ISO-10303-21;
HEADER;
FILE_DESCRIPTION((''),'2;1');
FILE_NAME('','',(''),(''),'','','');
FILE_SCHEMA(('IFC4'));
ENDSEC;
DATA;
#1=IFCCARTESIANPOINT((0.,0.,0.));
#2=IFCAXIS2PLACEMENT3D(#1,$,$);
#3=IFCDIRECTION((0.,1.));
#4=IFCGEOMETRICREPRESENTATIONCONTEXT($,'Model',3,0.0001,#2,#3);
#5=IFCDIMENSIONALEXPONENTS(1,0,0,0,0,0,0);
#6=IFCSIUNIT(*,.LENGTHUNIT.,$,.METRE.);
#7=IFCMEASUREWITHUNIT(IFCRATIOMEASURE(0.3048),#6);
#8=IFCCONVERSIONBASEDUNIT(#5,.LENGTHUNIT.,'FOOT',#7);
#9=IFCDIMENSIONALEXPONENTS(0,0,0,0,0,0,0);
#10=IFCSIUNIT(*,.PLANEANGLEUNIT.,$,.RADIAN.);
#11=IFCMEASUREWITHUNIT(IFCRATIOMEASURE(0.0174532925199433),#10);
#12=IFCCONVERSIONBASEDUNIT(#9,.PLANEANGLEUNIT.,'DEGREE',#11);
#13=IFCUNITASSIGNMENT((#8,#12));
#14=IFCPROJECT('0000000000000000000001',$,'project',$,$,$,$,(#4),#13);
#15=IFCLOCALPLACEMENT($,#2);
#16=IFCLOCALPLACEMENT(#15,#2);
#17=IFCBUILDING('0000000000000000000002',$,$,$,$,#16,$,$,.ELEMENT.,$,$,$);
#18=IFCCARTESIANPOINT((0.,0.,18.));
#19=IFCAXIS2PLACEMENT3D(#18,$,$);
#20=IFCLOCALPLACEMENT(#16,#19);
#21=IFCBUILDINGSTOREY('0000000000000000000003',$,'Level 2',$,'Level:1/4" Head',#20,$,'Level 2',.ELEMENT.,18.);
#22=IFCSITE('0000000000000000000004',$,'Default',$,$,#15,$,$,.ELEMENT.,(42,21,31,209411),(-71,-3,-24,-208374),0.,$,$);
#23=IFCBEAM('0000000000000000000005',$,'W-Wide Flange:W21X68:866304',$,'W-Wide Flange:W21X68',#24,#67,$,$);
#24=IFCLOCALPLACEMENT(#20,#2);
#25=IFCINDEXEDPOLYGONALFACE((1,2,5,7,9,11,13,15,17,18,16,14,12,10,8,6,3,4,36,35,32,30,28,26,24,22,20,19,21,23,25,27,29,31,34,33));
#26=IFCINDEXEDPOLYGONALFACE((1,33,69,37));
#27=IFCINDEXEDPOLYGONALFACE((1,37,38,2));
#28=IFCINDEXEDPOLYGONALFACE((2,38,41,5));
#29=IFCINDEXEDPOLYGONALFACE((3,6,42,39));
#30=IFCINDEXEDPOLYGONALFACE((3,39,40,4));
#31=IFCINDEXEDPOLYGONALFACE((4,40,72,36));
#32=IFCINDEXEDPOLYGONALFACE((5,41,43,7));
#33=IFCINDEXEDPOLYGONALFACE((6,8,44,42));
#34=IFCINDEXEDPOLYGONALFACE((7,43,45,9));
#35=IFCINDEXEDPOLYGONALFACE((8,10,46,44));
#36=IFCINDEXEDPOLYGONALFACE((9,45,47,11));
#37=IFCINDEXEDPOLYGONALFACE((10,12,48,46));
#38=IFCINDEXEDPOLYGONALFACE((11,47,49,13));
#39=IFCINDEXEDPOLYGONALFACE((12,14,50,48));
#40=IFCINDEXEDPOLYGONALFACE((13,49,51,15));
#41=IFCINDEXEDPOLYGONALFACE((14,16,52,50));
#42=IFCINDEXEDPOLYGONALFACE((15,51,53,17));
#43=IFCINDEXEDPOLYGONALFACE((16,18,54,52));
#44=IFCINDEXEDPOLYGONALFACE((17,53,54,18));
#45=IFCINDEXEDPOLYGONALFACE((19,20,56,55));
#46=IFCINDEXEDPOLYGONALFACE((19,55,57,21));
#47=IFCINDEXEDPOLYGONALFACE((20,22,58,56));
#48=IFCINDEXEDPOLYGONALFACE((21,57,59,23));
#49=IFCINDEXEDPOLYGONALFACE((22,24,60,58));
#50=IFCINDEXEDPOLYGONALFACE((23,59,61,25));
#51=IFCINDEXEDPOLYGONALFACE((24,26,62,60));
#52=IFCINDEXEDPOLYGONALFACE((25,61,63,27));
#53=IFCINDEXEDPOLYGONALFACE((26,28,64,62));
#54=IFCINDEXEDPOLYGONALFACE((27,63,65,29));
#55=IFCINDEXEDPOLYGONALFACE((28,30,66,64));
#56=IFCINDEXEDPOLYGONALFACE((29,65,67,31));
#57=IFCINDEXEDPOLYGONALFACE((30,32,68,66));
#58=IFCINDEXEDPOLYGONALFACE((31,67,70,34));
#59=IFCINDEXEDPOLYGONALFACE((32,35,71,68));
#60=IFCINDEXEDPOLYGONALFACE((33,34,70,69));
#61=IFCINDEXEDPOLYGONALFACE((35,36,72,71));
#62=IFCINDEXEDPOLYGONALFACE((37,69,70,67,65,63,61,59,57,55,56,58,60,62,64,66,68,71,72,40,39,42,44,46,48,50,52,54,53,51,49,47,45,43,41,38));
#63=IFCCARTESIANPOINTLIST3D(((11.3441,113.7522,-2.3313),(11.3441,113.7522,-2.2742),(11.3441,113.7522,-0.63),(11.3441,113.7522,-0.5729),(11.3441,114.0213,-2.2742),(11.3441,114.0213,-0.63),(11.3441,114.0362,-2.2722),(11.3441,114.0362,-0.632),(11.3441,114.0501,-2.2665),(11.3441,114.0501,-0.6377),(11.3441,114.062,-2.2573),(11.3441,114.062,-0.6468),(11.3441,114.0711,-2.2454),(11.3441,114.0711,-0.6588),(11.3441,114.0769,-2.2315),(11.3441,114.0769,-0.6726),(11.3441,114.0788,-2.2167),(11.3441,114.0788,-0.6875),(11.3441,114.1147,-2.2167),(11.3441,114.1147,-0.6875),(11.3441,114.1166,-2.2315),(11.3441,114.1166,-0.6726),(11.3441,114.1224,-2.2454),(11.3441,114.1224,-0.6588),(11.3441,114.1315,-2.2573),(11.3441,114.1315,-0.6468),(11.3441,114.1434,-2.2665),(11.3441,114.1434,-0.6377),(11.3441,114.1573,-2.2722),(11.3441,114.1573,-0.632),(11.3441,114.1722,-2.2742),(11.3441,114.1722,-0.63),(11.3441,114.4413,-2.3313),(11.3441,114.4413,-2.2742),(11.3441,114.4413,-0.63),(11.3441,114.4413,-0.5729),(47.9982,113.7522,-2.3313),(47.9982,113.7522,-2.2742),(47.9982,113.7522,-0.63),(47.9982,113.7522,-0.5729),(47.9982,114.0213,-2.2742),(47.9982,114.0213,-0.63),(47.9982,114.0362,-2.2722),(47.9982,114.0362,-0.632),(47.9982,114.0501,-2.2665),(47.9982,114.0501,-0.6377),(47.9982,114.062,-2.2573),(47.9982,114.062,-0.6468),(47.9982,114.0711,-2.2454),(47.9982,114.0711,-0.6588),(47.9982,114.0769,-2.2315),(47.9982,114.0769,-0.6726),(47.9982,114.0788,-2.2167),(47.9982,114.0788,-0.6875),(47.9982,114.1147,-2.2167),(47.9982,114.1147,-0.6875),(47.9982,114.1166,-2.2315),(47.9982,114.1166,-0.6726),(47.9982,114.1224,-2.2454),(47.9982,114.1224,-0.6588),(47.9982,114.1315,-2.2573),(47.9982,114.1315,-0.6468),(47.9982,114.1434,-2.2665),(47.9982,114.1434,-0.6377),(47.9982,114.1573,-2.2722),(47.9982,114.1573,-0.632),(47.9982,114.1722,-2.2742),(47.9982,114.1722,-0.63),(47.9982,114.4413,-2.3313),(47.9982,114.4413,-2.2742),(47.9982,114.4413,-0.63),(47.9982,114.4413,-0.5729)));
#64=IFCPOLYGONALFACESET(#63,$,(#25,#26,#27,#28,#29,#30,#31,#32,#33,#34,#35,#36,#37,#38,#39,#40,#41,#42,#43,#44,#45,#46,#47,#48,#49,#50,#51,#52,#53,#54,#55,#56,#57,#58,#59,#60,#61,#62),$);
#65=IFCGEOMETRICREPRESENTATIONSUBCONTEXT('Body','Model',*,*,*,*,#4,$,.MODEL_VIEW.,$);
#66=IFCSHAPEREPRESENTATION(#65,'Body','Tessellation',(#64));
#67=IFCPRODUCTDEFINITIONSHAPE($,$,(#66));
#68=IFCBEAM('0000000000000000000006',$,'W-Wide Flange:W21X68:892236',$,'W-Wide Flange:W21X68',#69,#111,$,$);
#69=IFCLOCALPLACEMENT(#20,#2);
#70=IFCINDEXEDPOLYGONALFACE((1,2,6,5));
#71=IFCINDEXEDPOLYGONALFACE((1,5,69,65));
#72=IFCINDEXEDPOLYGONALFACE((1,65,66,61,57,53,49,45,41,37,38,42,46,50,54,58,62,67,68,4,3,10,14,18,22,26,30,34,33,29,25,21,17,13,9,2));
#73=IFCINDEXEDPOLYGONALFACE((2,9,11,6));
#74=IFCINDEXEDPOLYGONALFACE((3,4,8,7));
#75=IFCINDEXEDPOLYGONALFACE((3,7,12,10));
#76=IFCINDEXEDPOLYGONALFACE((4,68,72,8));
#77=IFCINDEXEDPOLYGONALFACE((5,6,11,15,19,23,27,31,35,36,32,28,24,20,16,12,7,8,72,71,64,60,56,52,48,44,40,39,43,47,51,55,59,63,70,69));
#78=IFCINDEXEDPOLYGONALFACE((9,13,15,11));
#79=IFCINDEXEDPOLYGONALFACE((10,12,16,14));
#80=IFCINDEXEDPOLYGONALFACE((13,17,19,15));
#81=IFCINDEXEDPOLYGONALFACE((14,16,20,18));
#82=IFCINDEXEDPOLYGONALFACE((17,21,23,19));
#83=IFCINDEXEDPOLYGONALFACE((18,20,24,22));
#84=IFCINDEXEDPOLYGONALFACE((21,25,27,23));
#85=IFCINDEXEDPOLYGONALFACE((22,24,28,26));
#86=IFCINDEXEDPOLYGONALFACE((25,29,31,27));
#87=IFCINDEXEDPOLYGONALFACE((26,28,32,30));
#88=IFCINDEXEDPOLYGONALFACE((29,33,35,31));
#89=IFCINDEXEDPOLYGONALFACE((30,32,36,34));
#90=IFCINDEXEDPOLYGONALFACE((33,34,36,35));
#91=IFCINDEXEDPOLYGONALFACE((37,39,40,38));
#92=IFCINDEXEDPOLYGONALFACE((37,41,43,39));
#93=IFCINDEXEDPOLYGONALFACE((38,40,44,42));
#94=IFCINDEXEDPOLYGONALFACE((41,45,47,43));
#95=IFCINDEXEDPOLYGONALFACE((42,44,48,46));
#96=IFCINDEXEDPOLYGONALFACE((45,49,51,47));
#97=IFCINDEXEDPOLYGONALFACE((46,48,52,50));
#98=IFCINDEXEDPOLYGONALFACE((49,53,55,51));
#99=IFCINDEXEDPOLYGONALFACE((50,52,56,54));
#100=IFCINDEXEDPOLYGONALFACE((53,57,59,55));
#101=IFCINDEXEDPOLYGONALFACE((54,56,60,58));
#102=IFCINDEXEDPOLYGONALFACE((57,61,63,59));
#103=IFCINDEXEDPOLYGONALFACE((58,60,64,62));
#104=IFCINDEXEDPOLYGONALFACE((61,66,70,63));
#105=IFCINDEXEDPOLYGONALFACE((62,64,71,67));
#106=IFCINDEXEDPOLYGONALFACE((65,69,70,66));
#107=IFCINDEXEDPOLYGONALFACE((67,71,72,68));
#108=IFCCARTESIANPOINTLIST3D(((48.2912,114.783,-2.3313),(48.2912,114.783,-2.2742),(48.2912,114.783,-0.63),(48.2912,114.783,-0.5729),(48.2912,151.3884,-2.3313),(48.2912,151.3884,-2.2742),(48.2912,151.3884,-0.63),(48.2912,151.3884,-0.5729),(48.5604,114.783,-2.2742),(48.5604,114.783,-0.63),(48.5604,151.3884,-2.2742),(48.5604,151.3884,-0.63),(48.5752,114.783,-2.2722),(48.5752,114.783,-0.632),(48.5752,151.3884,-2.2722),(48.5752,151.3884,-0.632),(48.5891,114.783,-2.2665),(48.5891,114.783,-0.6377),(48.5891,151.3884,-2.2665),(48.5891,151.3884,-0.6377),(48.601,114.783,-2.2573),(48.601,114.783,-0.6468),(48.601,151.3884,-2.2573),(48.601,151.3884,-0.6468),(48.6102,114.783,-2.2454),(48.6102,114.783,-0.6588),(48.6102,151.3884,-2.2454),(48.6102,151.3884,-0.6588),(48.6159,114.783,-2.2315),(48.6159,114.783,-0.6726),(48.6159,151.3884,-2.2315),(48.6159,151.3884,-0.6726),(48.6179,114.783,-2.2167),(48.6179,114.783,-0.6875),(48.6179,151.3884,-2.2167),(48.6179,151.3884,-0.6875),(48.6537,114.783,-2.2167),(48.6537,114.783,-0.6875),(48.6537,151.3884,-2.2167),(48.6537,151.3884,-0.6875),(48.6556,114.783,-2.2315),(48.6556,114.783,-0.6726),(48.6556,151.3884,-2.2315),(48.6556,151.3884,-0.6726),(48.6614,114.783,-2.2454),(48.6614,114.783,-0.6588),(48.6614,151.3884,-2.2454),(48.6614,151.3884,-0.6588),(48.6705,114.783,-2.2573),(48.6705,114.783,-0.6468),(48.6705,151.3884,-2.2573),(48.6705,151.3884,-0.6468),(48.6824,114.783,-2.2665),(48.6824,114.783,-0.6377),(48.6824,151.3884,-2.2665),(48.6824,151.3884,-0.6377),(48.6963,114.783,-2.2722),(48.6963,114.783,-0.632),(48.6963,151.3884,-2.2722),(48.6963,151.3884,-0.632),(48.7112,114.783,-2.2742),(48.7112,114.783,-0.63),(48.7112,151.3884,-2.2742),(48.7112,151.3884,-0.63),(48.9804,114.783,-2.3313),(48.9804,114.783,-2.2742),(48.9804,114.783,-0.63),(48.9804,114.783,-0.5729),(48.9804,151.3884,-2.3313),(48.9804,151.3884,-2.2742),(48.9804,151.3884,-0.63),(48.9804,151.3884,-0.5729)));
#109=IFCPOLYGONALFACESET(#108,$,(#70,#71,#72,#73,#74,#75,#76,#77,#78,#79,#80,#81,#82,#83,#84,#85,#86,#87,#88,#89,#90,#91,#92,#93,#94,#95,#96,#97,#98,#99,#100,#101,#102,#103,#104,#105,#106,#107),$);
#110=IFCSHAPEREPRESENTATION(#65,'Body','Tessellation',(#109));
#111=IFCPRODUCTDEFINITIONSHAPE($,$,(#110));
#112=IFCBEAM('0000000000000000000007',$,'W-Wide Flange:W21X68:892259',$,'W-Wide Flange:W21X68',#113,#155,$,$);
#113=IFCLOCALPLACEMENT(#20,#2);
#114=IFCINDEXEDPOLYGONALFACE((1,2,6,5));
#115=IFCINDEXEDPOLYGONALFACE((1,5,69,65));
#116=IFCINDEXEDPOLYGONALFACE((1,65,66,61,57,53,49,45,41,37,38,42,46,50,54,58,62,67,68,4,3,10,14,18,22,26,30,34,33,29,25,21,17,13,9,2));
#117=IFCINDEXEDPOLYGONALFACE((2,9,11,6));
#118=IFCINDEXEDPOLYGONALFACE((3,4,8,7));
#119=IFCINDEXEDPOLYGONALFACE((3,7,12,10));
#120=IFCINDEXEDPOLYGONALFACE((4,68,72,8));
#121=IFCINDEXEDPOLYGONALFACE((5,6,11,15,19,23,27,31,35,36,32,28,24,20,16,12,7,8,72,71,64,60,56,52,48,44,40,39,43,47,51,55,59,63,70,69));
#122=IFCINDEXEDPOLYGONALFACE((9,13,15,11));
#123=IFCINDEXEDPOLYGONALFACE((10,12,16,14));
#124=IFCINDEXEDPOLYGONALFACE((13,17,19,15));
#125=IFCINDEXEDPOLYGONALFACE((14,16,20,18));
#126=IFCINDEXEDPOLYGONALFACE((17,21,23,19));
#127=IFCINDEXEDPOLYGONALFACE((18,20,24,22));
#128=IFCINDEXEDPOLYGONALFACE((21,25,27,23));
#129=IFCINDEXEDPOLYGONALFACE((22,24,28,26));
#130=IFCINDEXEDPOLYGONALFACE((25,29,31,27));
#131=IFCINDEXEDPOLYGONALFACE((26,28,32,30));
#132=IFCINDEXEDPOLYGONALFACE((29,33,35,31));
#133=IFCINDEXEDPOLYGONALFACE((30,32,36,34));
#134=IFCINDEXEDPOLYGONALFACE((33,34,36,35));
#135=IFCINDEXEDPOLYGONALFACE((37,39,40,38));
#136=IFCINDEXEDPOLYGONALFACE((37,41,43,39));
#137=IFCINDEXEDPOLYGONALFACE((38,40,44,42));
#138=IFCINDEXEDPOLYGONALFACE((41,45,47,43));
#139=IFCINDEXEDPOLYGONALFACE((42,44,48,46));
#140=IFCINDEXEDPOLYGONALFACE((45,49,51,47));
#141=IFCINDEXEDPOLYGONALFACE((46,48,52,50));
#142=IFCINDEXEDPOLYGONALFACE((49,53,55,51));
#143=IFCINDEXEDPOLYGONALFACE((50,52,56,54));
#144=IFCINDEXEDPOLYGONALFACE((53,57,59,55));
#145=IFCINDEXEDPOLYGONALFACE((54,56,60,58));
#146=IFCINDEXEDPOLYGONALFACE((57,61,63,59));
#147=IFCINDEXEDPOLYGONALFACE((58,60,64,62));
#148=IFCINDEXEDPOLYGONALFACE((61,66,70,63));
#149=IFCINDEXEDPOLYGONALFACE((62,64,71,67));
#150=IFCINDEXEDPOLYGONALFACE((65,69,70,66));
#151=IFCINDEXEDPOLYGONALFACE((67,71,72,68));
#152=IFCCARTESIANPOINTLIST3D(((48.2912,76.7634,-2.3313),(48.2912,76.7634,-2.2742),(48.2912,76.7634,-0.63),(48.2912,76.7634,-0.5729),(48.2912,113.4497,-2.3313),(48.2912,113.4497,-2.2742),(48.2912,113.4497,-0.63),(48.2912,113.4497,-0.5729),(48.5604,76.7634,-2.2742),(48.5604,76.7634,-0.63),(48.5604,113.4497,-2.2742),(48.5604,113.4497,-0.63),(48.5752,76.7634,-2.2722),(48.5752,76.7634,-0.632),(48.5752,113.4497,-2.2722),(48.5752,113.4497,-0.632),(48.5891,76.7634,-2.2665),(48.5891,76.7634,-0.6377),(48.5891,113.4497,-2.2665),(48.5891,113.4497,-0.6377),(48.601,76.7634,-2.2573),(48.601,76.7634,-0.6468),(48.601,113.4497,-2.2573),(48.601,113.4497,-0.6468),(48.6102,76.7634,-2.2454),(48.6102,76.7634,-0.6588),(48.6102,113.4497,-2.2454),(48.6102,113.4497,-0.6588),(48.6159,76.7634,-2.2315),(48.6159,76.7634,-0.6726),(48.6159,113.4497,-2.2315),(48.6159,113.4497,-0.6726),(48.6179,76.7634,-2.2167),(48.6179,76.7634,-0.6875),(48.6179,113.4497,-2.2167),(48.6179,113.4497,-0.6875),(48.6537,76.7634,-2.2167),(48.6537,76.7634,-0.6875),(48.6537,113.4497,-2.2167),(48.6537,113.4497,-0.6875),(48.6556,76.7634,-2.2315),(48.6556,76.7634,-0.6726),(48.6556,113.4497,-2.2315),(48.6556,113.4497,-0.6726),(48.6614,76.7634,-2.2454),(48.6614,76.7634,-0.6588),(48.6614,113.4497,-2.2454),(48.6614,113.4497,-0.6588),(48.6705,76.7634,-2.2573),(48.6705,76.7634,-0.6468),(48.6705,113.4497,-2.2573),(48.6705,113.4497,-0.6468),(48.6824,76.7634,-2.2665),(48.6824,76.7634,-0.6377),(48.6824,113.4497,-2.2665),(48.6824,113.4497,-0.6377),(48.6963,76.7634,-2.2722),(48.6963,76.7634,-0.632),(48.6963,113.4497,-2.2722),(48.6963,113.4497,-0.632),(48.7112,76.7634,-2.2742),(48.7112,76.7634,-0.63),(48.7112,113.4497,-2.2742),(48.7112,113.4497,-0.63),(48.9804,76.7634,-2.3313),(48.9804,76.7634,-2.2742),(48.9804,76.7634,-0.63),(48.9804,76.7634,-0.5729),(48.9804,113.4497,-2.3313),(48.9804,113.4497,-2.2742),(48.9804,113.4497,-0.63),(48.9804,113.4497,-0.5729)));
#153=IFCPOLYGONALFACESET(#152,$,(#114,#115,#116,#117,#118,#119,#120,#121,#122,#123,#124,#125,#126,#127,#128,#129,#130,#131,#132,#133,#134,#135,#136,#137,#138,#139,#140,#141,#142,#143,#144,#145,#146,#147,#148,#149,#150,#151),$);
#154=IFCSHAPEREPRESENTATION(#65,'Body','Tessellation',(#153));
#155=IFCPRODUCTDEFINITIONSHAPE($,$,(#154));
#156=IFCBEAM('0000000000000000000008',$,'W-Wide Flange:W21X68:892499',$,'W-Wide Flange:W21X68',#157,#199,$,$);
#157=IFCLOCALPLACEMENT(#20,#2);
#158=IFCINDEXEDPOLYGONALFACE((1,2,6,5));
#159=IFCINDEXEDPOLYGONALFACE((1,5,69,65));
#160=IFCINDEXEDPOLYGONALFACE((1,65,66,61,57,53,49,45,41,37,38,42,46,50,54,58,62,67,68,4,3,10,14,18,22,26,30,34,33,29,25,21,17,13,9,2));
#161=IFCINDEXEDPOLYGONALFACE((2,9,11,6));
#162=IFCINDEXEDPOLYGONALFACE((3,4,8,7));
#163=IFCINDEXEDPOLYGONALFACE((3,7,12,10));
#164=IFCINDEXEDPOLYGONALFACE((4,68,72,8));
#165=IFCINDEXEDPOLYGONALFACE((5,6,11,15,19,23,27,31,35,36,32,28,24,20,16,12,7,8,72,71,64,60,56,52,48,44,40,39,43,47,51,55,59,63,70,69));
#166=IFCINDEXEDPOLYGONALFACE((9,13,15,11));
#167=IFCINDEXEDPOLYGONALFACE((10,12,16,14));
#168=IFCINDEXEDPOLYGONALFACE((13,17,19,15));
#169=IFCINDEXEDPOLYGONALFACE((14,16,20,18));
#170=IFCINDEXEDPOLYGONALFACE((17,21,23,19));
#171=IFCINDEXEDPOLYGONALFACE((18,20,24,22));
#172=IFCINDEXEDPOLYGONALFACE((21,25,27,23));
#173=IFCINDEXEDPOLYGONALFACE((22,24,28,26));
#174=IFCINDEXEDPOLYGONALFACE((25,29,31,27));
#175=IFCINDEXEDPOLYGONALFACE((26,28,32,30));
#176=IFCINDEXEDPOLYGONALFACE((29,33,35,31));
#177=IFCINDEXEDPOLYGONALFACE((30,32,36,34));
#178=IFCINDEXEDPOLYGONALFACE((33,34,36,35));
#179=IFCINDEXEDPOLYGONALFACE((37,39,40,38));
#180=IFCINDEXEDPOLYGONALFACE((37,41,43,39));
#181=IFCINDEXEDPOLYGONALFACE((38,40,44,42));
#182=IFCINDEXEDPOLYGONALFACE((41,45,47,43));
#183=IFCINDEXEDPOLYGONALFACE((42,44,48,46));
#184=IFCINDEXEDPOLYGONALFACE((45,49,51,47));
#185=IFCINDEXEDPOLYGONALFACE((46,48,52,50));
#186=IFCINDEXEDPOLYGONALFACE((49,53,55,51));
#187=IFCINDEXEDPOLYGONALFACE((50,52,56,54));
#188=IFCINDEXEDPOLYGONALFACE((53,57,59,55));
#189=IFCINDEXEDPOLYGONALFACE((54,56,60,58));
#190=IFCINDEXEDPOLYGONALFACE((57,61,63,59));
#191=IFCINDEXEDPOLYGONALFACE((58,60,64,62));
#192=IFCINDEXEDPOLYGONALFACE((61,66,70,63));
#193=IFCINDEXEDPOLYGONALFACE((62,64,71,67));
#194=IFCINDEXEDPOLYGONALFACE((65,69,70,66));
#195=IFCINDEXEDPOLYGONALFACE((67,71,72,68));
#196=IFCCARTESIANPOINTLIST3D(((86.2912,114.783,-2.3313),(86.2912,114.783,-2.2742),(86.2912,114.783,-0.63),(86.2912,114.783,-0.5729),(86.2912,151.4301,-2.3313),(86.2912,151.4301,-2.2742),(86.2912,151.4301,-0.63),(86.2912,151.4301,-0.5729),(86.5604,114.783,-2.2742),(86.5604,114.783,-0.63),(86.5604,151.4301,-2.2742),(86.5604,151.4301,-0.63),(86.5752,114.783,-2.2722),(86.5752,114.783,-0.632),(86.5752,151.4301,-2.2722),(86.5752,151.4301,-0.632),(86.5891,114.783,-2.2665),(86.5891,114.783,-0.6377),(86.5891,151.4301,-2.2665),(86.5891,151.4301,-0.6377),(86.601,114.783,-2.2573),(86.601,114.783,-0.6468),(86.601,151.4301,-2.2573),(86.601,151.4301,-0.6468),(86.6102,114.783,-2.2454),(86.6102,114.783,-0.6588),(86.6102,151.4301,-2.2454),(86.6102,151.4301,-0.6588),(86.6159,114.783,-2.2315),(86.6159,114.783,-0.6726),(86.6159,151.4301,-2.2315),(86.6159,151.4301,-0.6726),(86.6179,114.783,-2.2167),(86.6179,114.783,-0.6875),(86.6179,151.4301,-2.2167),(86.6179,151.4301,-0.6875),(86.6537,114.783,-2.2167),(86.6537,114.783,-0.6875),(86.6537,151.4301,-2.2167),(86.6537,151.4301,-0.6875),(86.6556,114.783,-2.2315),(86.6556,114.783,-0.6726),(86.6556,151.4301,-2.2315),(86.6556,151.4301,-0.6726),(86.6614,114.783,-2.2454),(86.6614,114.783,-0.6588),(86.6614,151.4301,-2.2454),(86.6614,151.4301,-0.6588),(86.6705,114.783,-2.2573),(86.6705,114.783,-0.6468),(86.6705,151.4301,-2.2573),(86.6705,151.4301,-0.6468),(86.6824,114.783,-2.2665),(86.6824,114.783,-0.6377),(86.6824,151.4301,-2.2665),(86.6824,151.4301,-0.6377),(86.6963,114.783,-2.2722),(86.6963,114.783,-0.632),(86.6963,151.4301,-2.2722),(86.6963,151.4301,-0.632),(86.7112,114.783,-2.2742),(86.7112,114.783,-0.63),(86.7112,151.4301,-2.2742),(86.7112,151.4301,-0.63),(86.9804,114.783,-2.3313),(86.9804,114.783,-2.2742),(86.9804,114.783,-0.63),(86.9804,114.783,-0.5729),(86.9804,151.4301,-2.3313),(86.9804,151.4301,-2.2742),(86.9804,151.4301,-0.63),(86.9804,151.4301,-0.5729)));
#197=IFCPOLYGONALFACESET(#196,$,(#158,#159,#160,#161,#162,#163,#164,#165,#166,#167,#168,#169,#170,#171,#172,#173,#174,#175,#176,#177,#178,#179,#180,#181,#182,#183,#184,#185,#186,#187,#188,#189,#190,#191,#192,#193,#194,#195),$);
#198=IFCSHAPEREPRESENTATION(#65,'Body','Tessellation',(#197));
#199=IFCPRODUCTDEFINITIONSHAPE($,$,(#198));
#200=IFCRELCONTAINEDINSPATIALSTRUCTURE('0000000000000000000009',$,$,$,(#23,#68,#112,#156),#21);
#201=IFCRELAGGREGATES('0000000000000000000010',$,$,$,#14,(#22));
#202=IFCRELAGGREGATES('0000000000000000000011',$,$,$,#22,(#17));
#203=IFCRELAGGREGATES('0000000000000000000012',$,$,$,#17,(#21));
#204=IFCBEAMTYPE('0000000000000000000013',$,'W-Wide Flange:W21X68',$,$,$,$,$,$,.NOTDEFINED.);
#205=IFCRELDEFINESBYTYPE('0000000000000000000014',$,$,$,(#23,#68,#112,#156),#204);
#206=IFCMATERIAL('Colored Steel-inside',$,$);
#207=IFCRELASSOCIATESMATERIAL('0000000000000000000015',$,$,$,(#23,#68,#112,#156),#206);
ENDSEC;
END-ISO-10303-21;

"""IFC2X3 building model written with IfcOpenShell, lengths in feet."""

from ifc_helpers import new_model, entity, si_unit, converted_unit, direction, frame, frame_2d, origin, place, context, subcontext, project, spatial, i_section, extrude, material, type_object, element, save


model = new_model("IFC2X3")

# Units and contexts
model_context = context("Model", 3, precision=0.0001, world=origin(), true_north=direction((0.0, 1.0)))
body_context = subcontext(model_context, "Body", "Model", "MODEL_VIEW")
ifc_project = project(units=[converted_unit("LENGTHUNIT", "FOOT", entity("IfcRatioMeasure", 0.3048), si_unit("LENGTHUNIT", "METRE"), dimensions=[1, 0, 0, 0, 0, 0, 0]), converted_unit("PLANEANGLEUNIT", "DEGREE", entity("IfcRatioMeasure", 0.0174532925199433), si_unit("PLANEANGLEUNIT", "RADIAN"), dimensions=[0, 0, 0, 0, 0, 0, 0])], contexts=[model_context])

# Site, building, storey
site_placement = place(None, origin())
site = spatial("IfcSite", under=ifc_project, at=site_placement, Name="Default", CompositionType="ELEMENT", RefLatitude=(42, 21, 31, 209411), RefLongitude=(-71, -3, -24, -208374), RefElevation=0.0)
building_placement = place(site_placement, origin())
building = spatial("IfcBuilding", under=site, at=building_placement, CompositionType="ELEMENT")
storey_placement = place(building_placement, frame((0.0, 0.0, 18.0)))
storey = spatial("IfcBuildingStorey", under=building, at=storey_placement, Name="Level 2", ObjectType="Level:1/4\" Head", LongName="Level 2", CompositionType="ELEMENT", Elevation=18.0)

# Shared definitions
ifc_material_1 = material(Name="Colored Steel-inside")

# Beams
beam_type_1 = type_object("IfcBeamType", Name="W-Wide Flange:W21X68", PredefinedType="NOTDEFINED")
beam_1_placement = place(storey_placement, frame((10.6554, 114.0968, 0.0)))
element("IfcBeam", 1, at=beam_1_placement, inside=storey, type_object=beam_type_1, material=ifc_material_1, Name="W-Wide Flange:W21X68:866304", ObjectType="W-Wide Flange:W21X68", context=body_context, shape_type="SweptSolid", body=[
    extrude(i_section(OverallWidth=0.6892, OverallDepth=1.7583, WebThickness=0.0358, FlangeThickness=0.0571, FilletRadius=0.0575, at=frame_2d((0.0, 0.0), x_axis=(0.0, 1.0))), frame((0.6888, 0.0, -1.4521), z_axis=(1.0, 0.0, 0.0), x_axis=(0.0, 0.0, -1.0)), (0.0, 0.0, 1.0), 36.6541),
])
beam_2_placement = place(storey_placement, frame((48.6358, 152.0968, 0.0), z_axis=(0.0, 0.0, 1.0), x_axis=(0.0, -1.0, 0.0)))
element("IfcBeam", 2, at=beam_2_placement, inside=storey, type_object=beam_type_1, material=ifc_material_1, Name="W-Wide Flange:W21X68:892236", ObjectType="W-Wide Flange:W21X68", context=body_context, shape_type="SweptSolid", body=[
    extrude(i_section(OverallWidth=0.6892, OverallDepth=1.7583, WebThickness=0.0358, FlangeThickness=0.0571, FilletRadius=0.0575, at=frame_2d((0.0, 0.0), x_axis=(0.0, 1.0))), frame((0.7083, 0.0, -1.4521), z_axis=(1.0, 0.0, 0.0), x_axis=(0.0, 0.0, -1.0)), (0.0, 0.0, 1.0), 36.6054),
])
beam_3_placement = place(storey_placement, frame((48.6358, 114.0968, 0.0), z_axis=(0.0, 0.0, 1.0), x_axis=(0.0, -1.0, 0.0)))
element("IfcBeam", 3, at=beam_3_placement, inside=storey, type_object=beam_type_1, material=ifc_material_1, Name="W-Wide Flange:W21X68:892259", ObjectType="W-Wide Flange:W21X68", context=body_context, shape_type="SweptSolid", body=[
    extrude(i_section(OverallWidth=0.6892, OverallDepth=1.7583, WebThickness=0.0358, FlangeThickness=0.0571, FilletRadius=0.0575, at=frame_2d((0.0, 0.0), x_axis=(0.0, 1.0))), frame((0.6471, 0.0, -1.4521), z_axis=(1.0, 0.0, 0.0), x_axis=(0.0, 0.0, -1.0)), (0.0, 0.0, 1.0), 36.6863),
])
beam_4_placement = place(storey_placement, frame((86.6358, 152.0968, 0.0), z_axis=(0.0, 0.0, 1.0), x_axis=(0.0, -1.0, 0.0)))
element("IfcBeam", 4, at=beam_4_placement, inside=storey, type_object=beam_type_1, material=ifc_material_1, Name="W-Wide Flange:W21X68:892499", ObjectType="W-Wide Flange:W21X68", context=body_context, shape_type="SweptSolid", body=[
    extrude(i_section(OverallWidth=0.6892, OverallDepth=1.7583, WebThickness=0.0358, FlangeThickness=0.0571, FilletRadius=0.0575, at=frame_2d((0.0, 0.0), x_axis=(0.0, 1.0))), frame((0.6667, 0.0, -1.4521), z_axis=(1.0, 0.0, 0.0), x_axis=(0.0, 0.0, -1.0)), (0.0, 0.0, 1.0), 36.6471),
])

save(model, "model.ifc")
